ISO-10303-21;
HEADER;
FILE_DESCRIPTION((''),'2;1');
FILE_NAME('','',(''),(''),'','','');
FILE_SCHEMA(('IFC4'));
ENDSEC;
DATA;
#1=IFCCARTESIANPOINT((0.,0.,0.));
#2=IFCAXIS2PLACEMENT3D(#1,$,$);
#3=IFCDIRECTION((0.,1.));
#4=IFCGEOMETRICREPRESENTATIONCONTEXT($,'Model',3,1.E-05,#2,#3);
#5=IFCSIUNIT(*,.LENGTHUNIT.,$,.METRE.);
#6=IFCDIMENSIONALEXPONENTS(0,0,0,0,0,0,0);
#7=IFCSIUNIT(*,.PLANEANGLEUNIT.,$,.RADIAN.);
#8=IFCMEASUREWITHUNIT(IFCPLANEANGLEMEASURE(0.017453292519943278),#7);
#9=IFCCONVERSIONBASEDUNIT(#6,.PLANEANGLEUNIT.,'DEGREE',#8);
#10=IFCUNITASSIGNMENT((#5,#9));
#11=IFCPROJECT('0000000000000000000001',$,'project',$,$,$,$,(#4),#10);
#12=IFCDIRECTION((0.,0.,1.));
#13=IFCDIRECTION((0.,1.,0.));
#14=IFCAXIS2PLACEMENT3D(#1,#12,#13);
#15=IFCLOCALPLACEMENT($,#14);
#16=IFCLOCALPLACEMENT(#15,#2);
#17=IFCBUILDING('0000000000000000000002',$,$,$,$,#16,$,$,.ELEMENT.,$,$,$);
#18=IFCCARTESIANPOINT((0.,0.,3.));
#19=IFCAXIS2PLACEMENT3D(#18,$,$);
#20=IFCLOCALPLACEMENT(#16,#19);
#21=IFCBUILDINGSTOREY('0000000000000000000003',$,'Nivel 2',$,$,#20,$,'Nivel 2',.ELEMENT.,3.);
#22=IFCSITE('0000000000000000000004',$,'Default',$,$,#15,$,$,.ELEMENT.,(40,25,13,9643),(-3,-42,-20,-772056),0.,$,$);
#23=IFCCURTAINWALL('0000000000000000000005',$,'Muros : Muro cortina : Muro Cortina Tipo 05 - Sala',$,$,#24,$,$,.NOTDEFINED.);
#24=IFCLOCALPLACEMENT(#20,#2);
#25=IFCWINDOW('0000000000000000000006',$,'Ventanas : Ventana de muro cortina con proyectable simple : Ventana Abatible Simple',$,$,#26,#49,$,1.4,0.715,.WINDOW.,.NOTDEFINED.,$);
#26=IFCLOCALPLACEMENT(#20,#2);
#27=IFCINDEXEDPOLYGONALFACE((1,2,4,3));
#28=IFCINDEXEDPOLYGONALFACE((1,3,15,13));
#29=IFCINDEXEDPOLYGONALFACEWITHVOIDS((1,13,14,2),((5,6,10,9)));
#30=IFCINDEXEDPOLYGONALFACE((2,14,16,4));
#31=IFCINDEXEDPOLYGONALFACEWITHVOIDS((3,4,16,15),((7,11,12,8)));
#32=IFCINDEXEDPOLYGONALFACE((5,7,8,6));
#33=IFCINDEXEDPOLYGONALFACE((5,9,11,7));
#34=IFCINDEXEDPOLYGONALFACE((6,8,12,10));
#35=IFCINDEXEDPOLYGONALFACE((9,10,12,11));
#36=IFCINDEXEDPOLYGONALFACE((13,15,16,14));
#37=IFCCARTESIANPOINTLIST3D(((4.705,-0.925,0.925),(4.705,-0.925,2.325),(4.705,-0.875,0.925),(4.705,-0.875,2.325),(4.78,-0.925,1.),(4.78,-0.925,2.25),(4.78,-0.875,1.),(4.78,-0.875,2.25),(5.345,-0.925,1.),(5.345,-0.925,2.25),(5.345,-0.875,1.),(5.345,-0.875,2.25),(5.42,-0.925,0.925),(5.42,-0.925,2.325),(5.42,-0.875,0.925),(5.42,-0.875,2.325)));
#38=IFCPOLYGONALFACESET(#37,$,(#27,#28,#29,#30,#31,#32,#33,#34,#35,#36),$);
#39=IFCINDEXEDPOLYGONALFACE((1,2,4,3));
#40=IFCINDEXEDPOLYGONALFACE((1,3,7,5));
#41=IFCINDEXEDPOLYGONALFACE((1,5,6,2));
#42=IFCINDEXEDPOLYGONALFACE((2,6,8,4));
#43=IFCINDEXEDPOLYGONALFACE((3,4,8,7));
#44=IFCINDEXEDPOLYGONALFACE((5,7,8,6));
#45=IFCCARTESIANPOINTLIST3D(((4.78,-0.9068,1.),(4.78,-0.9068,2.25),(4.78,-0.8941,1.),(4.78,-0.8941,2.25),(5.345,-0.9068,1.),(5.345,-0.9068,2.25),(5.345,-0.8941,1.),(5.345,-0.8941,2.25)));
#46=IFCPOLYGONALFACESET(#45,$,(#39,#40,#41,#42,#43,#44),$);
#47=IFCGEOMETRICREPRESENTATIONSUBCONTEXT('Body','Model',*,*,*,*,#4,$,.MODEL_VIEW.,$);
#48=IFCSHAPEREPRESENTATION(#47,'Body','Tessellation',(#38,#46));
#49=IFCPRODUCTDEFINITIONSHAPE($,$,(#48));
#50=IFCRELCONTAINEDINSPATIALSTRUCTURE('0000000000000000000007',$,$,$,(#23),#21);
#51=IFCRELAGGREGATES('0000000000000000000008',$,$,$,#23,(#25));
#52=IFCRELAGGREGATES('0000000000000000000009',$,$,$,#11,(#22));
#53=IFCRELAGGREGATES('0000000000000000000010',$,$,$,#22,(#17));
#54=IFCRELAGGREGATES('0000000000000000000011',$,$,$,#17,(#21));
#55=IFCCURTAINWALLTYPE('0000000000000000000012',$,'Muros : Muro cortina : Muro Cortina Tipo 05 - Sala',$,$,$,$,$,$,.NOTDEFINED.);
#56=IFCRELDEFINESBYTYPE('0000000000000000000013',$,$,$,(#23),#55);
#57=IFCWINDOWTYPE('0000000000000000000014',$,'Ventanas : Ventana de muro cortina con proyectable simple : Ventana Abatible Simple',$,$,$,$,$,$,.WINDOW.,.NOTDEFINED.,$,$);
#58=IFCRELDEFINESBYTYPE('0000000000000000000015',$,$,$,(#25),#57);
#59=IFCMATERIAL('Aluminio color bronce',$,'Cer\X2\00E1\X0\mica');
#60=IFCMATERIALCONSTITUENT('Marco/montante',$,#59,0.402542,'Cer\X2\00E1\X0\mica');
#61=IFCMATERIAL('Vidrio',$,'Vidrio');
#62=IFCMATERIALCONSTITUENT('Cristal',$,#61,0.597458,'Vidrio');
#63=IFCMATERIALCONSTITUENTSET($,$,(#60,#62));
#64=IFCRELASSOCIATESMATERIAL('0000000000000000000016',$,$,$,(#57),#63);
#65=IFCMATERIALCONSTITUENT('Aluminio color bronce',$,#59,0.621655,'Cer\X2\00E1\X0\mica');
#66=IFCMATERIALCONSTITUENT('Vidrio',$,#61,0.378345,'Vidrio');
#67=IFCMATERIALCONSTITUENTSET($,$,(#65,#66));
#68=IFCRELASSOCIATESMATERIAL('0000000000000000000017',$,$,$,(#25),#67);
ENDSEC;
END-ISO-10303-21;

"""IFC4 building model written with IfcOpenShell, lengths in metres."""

from ifc_helpers import new_model, entity, si_unit, converted_unit, direction, frame, origin, place, context, subcontext, project, spatial, indexed_curve, outline, extrude, source, transform, mapped, material, constituent, constituent_set, type_object, type_shapes, element, aggregate, save


model = new_model("IFC4")

# Units and contexts
model_context = context("Model", 3, precision=1e-05, world=origin(), true_north=direction((0.0, 1.0)))
body_context = subcontext(model_context, "Body", "Model", "MODEL_VIEW")
ifc_project = project(units=[si_unit("LENGTHUNIT", "METRE"), converted_unit("PLANEANGLEUNIT", "DEGREE", entity("IfcPlaneAngleMeasure", 0.017453292519943278), si_unit("PLANEANGLEUNIT", "RADIAN"), dimensions=[0, 0, 0, 0, 0, 0, 0])], contexts=[model_context])

# Site, building, storey
site_placement = place(None, frame((0.0, 0.0, 0.0), z_axis=(0.0, 0.0, 1.0), x_axis=(0.0, 1.0, 0.0)))
site = spatial("IfcSite", under=ifc_project, at=site_placement, Name="Default", CompositionType="ELEMENT", RefLatitude=(40, 25, 13, 9643), RefLongitude=(-3, -42, -20, -772056), RefElevation=0.0)
building_placement = place(site_placement, origin())
building = spatial("IfcBuilding", under=site, at=building_placement, CompositionType="ELEMENT")
storey_placement = place(building_placement, frame((0.0, 0.0, 3.0)))
storey = spatial("IfcBuildingStorey", under=building, at=storey_placement, Name="Nivel 2", LongName="Nivel 2", CompositionType="ELEMENT", Elevation=3.0)

# Curtain wall, window
curtain_wall_type = type_object("IfcCurtainWallType", Name="Muros : Muro cortina : Muro Cortina Tipo 05 - Sala", PredefinedType="NOTDEFINED")
curtain_wall_placement = place(storey_placement, frame((0.0, 0.0, -3.0)))
curtain_wall = element("IfcCurtainWall", 1, at=curtain_wall_placement, inside=storey, type_object=curtain_wall_type, Name="Muros : Muro cortina : Muro Cortina Tipo 05 - Sala", PredefinedType="NOTDEFINED")
ifc_material_1 = material(Name="Aluminio color bronce", Category="Cerámica")
ifc_material_2 = material(Name="Vidrio", Category="Vidrio")
ifc_constituent_1 = constituent(ifc_material_1, Name="Aluminio color bronce", Category="Cerámica", fraction=0.621655)
ifc_constituent_2 = constituent(ifc_material_2, Name="Vidrio", Category="Vidrio", fraction=0.378345)
ifc_constituent_set_1 = constituent_set(constituents=[ifc_constituent_1, ifc_constituent_2])
ifc_constituent_3 = constituent(ifc_material_1, Name="Marco/montante", Category="Cerámica", fraction=0.402542)
ifc_constituent_4 = constituent(ifc_material_2, Name="Cristal", Category="Vidrio", fraction=0.597458)
ifc_constituent_set_2 = constituent_set(constituents=[ifc_constituent_3, ifc_constituent_4])
window_type_1 = type_object("IfcWindowType", Name="Ventanas : Ventana de muro cortina con proyectable simple : Ventana Abatible Simple", PartitioningType="NOTDEFINED", PredefinedType="WINDOW", material=ifc_constituent_set_2)
shared_shape_1 = source(origin(), body_context, "Body", "SweptSolid", [
    extrude(outline(indexed_curve([(-0.3575, -0.7), (0.3575, -0.7), (0.3575, 0.7), (-0.3575, 0.7), (-0.3575, -0.7)], self_intersect=False), holes=[indexed_curve([(-0.2825, -0.625), (-0.2825, 0.625), (0.2825, 0.625), (0.2825, -0.625), (-0.2825, -0.625)], self_intersect=False)]), frame((0.0, -0.025, 0.7), z_axis=(0.0, 1.0, 0.0), x_axis=(1.0, 0.0, 0.0)), (0.0, 0.0, 1.0), 0.05),
    extrude(outline(indexed_curve([(-0.0063, -0.2825), (0.0063, -0.2825), (0.0063, 0.2825), (-0.0063, 0.2825), (-0.0063, -0.2825)], self_intersect=False)), frame((0.0, 0.0004, 0.075), z_axis=(0.0, 0.0, 1.0), x_axis=(0.0, 1.0, 0.0)), (0.0, 0.0, 1.0), 1.25),
])
type_shapes(window_type_1, [shared_shape_1])
window_1_placement = place(curtain_wall_placement, frame((5.0625, -0.9, 3.925), z_axis=(0.0, 0.0, 1.0), x_axis=(-1.0, 0.0, 0.0)))
window_1 = element("IfcWindow", 2, at=window_1_placement, type_object=window_type_1, material=ifc_constituent_set_1, Name="Ventanas : Ventana de muro cortina con proyectable simple : Ventana Abatible Simple", OverallHeight=1.4, OverallWidth=0.715, PartitioningType="NOTDEFINED", PredefinedType="WINDOW", context=body_context, shape_type="MappedRepresentation", body=[
    mapped(shared_shape_1, transform((0.0, 0.0, 0.0), scale=1.0)),
])
aggregate(curtain_wall, [window_1])

save(model, "model.ifc")
